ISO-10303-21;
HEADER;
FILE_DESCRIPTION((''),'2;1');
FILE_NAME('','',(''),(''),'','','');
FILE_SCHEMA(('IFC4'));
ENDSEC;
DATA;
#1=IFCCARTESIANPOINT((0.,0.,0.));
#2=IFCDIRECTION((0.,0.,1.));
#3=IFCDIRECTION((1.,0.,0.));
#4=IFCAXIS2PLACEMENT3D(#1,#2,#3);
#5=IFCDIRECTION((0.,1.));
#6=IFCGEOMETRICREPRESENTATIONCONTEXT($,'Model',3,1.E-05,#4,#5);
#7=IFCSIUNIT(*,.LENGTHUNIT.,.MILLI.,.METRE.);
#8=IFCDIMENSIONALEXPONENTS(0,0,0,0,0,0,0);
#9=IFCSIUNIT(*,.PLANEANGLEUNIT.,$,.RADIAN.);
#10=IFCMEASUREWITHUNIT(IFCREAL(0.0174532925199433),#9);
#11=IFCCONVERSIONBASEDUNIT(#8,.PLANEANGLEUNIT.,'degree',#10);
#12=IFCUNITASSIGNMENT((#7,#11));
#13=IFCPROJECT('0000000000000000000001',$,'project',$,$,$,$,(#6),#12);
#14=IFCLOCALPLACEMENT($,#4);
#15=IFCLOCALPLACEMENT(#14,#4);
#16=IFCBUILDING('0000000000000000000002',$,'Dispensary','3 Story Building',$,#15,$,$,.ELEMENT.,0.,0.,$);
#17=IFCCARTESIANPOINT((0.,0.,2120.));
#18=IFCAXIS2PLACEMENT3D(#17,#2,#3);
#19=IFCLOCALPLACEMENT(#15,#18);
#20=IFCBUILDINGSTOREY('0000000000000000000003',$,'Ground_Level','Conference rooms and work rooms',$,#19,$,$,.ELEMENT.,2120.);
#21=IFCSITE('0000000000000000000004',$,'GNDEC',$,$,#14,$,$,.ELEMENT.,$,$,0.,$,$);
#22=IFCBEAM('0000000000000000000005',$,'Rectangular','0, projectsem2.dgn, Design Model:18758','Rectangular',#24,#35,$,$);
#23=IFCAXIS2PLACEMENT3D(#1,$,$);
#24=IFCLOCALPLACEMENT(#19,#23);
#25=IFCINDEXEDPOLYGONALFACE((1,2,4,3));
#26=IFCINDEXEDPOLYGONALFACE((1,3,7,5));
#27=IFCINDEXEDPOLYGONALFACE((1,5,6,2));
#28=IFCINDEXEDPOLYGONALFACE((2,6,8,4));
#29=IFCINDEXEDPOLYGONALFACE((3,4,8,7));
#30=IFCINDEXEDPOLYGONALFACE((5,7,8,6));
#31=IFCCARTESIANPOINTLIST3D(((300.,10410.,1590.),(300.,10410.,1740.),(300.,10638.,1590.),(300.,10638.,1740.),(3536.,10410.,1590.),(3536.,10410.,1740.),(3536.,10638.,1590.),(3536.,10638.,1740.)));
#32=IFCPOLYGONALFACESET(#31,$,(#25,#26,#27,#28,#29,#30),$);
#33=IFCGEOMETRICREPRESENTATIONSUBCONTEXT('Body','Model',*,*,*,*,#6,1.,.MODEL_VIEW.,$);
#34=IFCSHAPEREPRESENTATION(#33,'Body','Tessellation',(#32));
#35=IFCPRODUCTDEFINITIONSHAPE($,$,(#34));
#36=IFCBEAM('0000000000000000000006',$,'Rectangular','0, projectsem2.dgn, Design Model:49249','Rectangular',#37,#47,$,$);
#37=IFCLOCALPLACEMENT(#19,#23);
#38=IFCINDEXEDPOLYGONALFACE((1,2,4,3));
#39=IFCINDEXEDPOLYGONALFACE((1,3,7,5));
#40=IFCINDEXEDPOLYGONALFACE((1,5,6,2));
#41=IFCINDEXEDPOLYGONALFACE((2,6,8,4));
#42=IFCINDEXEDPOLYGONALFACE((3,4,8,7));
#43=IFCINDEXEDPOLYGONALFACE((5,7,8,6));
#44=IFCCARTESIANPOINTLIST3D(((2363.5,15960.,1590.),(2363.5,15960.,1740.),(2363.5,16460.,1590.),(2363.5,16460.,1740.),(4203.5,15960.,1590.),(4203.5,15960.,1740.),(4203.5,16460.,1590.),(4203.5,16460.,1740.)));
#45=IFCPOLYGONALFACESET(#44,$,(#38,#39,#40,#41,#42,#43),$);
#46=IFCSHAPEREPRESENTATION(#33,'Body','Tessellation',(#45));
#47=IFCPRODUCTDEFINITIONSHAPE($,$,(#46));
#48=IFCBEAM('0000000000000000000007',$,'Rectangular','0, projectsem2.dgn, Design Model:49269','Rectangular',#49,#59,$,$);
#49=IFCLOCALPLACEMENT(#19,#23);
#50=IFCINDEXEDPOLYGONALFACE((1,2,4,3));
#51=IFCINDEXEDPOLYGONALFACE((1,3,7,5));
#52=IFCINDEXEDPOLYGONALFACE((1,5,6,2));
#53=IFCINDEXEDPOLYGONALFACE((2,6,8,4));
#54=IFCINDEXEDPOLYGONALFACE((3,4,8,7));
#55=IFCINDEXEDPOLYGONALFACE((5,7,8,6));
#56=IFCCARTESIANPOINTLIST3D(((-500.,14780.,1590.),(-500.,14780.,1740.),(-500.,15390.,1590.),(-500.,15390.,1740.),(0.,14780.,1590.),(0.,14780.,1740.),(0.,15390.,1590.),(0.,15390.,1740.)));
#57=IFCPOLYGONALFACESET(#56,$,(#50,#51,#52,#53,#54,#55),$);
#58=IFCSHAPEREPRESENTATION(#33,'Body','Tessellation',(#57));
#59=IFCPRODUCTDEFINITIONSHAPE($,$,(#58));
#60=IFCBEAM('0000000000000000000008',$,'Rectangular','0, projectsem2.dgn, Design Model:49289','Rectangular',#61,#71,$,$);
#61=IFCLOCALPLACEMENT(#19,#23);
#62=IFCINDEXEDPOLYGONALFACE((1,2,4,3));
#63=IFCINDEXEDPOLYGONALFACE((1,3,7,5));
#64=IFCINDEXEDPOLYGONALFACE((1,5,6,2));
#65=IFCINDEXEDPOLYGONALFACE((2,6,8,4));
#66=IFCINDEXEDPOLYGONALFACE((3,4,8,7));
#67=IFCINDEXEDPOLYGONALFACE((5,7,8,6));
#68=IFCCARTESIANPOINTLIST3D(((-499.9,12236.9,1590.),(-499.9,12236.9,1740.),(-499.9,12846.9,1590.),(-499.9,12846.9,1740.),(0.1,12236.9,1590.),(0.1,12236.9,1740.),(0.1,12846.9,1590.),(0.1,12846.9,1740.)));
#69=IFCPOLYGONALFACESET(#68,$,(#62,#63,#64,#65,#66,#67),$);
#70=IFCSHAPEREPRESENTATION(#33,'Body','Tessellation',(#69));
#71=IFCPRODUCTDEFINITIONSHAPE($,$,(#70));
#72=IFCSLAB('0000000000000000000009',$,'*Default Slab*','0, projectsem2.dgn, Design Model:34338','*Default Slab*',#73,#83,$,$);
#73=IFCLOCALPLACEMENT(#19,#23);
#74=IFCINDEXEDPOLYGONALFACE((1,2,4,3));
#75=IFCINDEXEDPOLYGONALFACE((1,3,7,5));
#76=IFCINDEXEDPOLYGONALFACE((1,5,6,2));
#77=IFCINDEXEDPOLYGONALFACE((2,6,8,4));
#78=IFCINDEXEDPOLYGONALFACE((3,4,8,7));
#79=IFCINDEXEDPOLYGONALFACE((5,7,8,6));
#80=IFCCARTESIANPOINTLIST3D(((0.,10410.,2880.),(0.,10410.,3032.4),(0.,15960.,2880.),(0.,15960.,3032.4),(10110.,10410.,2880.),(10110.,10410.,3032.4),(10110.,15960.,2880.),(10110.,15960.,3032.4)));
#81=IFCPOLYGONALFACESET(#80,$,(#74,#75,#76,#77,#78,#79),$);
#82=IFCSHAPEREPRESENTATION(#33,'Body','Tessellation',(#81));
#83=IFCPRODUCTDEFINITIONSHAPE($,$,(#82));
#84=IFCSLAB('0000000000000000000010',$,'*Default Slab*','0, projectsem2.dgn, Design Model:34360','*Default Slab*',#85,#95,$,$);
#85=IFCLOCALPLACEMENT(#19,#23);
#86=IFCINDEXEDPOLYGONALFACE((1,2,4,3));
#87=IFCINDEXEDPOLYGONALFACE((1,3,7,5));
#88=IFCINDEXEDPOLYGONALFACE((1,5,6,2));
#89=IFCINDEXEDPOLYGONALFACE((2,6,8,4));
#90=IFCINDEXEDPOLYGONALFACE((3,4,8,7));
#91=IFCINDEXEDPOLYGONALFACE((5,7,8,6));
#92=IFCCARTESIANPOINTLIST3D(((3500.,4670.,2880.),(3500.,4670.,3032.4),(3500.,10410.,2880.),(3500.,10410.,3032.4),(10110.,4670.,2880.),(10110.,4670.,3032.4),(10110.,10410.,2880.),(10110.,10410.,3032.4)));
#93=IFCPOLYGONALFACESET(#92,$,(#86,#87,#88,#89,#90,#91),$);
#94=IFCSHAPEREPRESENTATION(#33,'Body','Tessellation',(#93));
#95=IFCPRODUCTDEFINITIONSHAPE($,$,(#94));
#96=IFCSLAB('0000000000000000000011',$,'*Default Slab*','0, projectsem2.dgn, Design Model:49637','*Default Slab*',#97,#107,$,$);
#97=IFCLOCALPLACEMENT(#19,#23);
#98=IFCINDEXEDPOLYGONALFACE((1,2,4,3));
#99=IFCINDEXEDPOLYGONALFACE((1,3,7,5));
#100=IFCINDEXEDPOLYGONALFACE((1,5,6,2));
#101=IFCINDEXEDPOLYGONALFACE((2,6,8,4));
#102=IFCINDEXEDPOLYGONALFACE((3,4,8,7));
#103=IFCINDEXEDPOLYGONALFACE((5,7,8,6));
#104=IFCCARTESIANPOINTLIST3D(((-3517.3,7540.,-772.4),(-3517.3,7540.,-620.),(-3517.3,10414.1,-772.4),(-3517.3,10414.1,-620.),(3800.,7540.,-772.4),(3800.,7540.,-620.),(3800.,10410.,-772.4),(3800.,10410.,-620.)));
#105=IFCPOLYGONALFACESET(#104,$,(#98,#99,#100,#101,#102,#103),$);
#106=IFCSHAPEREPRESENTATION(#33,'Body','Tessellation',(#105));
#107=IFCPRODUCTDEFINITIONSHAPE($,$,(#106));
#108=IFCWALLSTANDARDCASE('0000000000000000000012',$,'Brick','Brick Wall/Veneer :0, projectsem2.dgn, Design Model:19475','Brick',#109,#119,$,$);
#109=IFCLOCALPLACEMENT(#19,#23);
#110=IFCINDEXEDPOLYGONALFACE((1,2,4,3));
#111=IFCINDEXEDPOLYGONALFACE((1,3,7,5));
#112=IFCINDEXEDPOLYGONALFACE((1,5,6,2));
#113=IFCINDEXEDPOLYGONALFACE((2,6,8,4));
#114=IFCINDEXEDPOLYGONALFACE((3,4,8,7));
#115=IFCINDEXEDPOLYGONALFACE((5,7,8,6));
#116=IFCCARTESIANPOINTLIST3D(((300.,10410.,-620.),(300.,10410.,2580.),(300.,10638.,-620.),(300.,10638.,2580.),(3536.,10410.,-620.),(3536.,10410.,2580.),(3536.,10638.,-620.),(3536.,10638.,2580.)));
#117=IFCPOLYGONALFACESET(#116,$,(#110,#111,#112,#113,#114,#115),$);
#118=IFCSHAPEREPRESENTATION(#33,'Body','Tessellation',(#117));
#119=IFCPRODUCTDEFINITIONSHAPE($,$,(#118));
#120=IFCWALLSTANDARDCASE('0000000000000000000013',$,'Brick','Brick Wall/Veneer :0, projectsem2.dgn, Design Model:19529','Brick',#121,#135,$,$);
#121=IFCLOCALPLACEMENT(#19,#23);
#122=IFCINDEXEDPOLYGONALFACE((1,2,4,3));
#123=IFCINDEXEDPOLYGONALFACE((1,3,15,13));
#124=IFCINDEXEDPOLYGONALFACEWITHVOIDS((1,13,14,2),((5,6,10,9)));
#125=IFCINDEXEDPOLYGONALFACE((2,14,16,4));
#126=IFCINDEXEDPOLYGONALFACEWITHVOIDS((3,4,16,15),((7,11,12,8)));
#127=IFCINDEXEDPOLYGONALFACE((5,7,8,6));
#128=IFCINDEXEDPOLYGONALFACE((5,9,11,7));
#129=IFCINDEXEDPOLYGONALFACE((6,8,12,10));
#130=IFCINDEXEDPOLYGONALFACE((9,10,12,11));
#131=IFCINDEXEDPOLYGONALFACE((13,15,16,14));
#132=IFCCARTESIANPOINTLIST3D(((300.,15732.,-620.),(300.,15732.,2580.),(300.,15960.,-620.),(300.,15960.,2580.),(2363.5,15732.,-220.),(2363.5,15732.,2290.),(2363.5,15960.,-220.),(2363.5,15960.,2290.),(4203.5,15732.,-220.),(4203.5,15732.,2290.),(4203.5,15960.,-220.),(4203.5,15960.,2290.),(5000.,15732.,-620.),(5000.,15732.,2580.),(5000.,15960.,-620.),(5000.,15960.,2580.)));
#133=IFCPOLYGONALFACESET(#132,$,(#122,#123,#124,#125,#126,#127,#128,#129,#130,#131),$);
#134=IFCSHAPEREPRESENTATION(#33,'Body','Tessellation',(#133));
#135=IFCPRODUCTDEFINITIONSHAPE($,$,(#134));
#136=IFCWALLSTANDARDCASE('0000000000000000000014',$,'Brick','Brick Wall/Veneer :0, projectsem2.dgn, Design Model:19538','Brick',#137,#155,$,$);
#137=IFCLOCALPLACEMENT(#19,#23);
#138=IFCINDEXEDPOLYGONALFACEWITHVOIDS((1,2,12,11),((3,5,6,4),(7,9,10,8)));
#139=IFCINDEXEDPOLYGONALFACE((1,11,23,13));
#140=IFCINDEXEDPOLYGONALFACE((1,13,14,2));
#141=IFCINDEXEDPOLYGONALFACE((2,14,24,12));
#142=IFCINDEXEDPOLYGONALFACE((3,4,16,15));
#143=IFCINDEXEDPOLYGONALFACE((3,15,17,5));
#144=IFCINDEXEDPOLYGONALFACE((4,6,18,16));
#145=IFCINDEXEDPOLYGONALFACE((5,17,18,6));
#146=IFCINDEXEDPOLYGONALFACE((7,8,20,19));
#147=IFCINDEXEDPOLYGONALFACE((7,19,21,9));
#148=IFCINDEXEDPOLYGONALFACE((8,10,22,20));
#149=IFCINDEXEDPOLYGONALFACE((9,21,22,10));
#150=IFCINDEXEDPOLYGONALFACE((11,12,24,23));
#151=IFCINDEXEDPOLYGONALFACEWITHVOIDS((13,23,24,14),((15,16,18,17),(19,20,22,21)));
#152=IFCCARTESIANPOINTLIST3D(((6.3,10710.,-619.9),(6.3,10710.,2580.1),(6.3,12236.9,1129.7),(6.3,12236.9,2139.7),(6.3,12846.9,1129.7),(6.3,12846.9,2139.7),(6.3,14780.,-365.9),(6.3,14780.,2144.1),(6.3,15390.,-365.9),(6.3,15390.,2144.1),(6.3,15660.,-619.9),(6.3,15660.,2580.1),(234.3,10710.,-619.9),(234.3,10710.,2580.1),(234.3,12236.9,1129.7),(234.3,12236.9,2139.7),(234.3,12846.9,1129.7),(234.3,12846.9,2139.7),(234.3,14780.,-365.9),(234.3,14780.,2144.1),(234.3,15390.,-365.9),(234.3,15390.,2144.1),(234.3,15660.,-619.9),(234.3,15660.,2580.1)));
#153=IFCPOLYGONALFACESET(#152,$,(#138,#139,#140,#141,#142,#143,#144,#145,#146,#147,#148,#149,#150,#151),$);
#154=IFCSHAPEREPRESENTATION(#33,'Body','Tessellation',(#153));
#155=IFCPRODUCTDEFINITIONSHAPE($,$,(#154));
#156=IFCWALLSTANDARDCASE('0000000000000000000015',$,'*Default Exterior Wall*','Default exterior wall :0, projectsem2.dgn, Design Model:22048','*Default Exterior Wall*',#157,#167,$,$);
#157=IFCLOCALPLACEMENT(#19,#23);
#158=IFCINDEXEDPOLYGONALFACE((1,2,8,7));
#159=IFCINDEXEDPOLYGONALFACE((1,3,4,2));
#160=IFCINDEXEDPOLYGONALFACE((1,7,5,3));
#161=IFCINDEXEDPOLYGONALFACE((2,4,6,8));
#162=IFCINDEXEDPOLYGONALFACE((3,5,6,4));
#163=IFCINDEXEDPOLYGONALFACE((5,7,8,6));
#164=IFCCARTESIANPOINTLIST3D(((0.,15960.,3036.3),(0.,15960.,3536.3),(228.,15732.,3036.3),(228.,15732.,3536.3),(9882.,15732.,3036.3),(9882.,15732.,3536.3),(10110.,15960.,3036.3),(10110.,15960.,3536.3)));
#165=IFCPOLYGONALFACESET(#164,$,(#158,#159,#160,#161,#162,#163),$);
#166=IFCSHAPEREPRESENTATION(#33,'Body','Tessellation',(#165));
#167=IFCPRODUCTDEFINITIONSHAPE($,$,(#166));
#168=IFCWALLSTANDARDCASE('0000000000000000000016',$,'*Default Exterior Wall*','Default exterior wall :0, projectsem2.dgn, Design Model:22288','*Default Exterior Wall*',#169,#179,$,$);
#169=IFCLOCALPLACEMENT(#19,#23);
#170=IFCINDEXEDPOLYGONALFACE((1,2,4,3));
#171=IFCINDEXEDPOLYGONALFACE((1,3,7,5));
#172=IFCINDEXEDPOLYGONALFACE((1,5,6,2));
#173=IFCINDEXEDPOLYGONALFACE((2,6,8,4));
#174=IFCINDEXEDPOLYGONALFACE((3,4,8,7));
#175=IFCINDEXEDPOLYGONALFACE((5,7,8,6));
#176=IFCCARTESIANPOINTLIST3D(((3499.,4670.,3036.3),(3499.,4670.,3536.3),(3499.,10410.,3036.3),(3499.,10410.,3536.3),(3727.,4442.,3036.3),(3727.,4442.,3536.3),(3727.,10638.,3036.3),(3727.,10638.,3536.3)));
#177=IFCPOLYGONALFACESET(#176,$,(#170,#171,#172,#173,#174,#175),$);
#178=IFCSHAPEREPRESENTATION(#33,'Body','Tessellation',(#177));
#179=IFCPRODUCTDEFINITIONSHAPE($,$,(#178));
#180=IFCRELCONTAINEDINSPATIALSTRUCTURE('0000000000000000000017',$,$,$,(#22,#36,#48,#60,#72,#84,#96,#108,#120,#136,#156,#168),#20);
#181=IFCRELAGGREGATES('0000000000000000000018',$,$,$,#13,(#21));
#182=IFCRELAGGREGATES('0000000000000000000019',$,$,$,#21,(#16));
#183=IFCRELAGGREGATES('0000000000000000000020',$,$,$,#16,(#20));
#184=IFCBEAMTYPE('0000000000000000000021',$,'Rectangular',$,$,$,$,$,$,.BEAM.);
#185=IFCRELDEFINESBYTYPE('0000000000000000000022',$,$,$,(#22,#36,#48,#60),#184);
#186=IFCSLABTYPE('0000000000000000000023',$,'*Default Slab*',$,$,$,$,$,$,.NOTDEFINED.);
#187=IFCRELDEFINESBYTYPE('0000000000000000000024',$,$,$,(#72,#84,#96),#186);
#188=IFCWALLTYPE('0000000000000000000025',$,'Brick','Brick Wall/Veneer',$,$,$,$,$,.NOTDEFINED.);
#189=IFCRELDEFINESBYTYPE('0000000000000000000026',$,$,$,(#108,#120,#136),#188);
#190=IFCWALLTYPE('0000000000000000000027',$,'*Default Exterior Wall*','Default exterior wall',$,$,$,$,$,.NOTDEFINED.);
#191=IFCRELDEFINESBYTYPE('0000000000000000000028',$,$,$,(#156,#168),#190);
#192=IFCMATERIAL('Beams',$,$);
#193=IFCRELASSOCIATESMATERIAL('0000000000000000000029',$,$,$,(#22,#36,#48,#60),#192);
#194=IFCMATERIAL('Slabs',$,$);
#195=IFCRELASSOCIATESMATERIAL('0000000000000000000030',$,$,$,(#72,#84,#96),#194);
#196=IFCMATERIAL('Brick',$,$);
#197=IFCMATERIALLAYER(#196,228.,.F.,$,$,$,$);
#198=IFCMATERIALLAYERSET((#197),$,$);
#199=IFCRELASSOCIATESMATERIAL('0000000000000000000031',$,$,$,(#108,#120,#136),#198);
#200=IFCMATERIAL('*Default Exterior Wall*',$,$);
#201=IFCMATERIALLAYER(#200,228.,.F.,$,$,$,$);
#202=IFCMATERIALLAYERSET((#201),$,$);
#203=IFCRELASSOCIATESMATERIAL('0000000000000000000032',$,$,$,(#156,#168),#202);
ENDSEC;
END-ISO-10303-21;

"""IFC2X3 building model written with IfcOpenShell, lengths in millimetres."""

from ifc_helpers import new_model, entity, si_unit, converted_unit, direction, frame, frame_2d, origin_with_axes, place, context, subcontext, project, spatial, polyline, rectangle, outline, extrude, material, layer, layer_set, layer_usage, type_object, element, save


model = new_model("IFC2X3")

# Units and contexts
model_context = context("Model", 3, precision=1e-05, world=origin_with_axes(), true_north=direction((0.0, 1.0)))
body_context = subcontext(model_context, "Body", "Model", "MODEL_VIEW", scale=1.0)
ifc_project = project(units=[si_unit("LENGTHUNIT", "METRE", prefix="MILLI"), converted_unit("PLANEANGLEUNIT", "degree", entity("IfcReal", 0.0174532925199433), si_unit("PLANEANGLEUNIT", "RADIAN"), dimensions=[0, 0, 0, 0, 0, 0, 0])], contexts=[model_context])

# Site, building, storey
site_placement = place(None, origin_with_axes())
site = spatial("IfcSite", under=ifc_project, at=site_placement, Name="GNDEC", CompositionType="ELEMENT", RefElevation=0.0)
building_placement = place(site_placement, origin_with_axes())
building = spatial("IfcBuilding", under=site, at=building_placement, Name="Dispensary", Description="3 Story Building", CompositionType="ELEMENT", ElevationOfRefHeight=0.0, ElevationOfTerrain=0.0)
storey_placement = place(building_placement, frame((0.0, 0.0, 2120.0), z_axis=(0.0, 0.0, 1.0), x_axis=(1.0, 0.0, 0.0)))
storey = spatial("IfcBuildingStorey", under=building, at=storey_placement, Name="Ground_Level", Description="Conference rooms and work rooms", CompositionType="ELEMENT", Elevation=2120.0)

# Beams
ifc_material_1 = material(Name="Beams")
beam_type = type_object("IfcBeamType", Name="Rectangular", PredefinedType="BEAM")
beam_1_placement = place(storey_placement, frame((300.0, 10410.0, 1590.0), z_axis=(1.0, 0.0, 0.0), x_axis=(0.0, 1.0, 0.0)))
element("IfcBeam", 1, at=beam_1_placement, inside=storey, type_object=beam_type, material=ifc_material_1, Name="Rectangular", Description="0, projectsem2.dgn, Design Model:18758", ObjectType="Rectangular", context=body_context, shape_type="SweptSolid", body=[
    extrude(rectangle(XDim=150.0, YDim=228.0, at=frame_2d((114.0, 75.0), x_axis=(0.0, 1.0))), origin_with_axes(), (0.0, 0.0, 1.0), 3236.0),
])
beam_2_placement = place(storey_placement, frame((4203.5, 16460.0, 1590.0), z_axis=(-1.0, 0.0, 0.0), x_axis=(0.0, -1.0, 0.0)))
element("IfcBeam", 2, at=beam_2_placement, inside=storey, type_object=beam_type, material=ifc_material_1, Name="Rectangular", Description="0, projectsem2.dgn, Design Model:49249", ObjectType="Rectangular", context=body_context, shape_type="SweptSolid", body=[
    extrude(rectangle(XDim=150.0, YDim=500.0, at=frame_2d((250.0, 75.0), x_axis=(0.0, 1.0))), origin_with_axes(), (0.0, 0.0, 1.0), 1840.0),
])
for number, where, z_axis, x_axis, name, description in (
    (3, (-500.0, 15390.0, 1590.0), (0.000031, -1.0, 0.0), (1.0, 0.000031, 0.0), "Rectangular", "0, projectsem2.dgn, Design Model:49269"),
    (4, (-499.9, 12846.9, 1590.0), (0.000031, -1.0, 0.0), (1.0, 0.000031, 0.0), "Rectangular", "0, projectsem2.dgn, Design Model:49289"),
):
    element("IfcBeam", number, at=place(storey_placement, frame(where, z_axis=z_axis, x_axis=x_axis)), inside=storey, type_object=beam_type, material=ifc_material_1, Name=name, Description=description, ObjectType="Rectangular", context=body_context, shape_type="SweptSolid", body=[
        extrude(rectangle(XDim=150.0, YDim=500.0, at=frame_2d((250.0, 75.0), x_axis=(0.0, 1.0))), origin_with_axes(), (0.0, 0.0, 1.0), 610.0),
    ])

# Slabs
ifc_material_2 = material(Name="Slabs")
slab_type = type_object("IfcSlabType", Name="*Default Slab*", PredefinedType="NOTDEFINED")
slab_1_placement = place(storey_placement, frame((0.0, 10410.0, 2880.0), z_axis=(0.0, 0.0, 1.0), x_axis=(1.0, 0.0, 0.0)))
element("IfcSlab", 5, at=slab_1_placement, inside=storey, type_object=slab_type, material=ifc_material_2, Name="*Default Slab*", Description="0, projectsem2.dgn, Design Model:34338", ObjectType="*Default Slab*", context=body_context, shape_type="SweptSolid", body=[
    extrude(rectangle(XDim=10110.0, YDim=5550.0, at=frame_2d((5055.0, 2775.0), x_axis=(1.0, 0.0))), origin_with_axes(), (0.0, 0.0, 1.0), 152.4),
])
slab_2_placement = place(storey_placement, frame((3500.0, 10410.0, 2880.0), z_axis=(0.0, 0.0, 1.0), x_axis=(0.0, -1.0, 0.0)))
element("IfcSlab", 6, at=slab_2_placement, inside=storey, type_object=slab_type, material=ifc_material_2, Name="*Default Slab*", Description="0, projectsem2.dgn, Design Model:34360", ObjectType="*Default Slab*", context=body_context, shape_type="SweptSolid", body=[
    extrude(rectangle(XDim=5740.0, YDim=6610.0, at=frame_2d((2870.0, 3305.0), x_axis=(1.0, 0.0))), origin_with_axes(), (0.0, 0.0, 1.0), 152.4),
])
slab_3_placement = place(storey_placement, frame((3800.0, 10410.0, -620.0), z_axis=(0.0, 0.0, -1.0), x_axis=(0.0, -1.0, 0.0)))
element("IfcSlab", 7, at=slab_3_placement, inside=storey, type_object=slab_type, material=ifc_material_2, Name="*Default Slab*", Description="0, projectsem2.dgn, Design Model:49637", ObjectType="*Default Slab*", context=body_context, shape_type="SweptSolid", body=[
    extrude(outline(polyline([(0.0, 0.0), (2870.0, 0.0), (2870.0, 7317.3), (-4.1, 7317.3), (0.0, 0.0)])), origin_with_axes(), (0.0, 0.0, 1.0), 152.4),
])

# Wall
ifc_material_3 = material(Name="Brick")
ifc_layer_1 = layer(ifc_material_3, 228.0, ventilated=False)
ifc_layer_set_1 = layer_set([ifc_layer_1])
ifc_layer_usage_1 = layer_usage(ifc_layer_set_1, "AXIS2", "POSITIVE", 0.0)
wall_type_1 = type_object("IfcWallType", Name="Brick", Description="Brick Wall/Veneer", PredefinedType="NOTDEFINED")
wall_1_placement = place(storey_placement, frame((300.0, 10638.0, -620.0), z_axis=(0.0, 0.0, 1.0), x_axis=(1.0, 0.0, 0.0)))
element("IfcWallStandardCase", 8, at=wall_1_placement, inside=storey, type_object=wall_type_1, material=ifc_layer_usage_1, Name="Brick", Description="Brick Wall/Veneer :0, projectsem2.dgn, Design Model:19475", ObjectType="Brick", context=body_context, shape_type="SweptSolid", body=[
    extrude(rectangle(XDim=228.0, YDim=3236.0, at=frame_2d((1618.0, -114.0), x_axis=(0.0, -1.0))), origin_with_axes(), (0.0, 0.0, 1.0), 3200.0),
])

# Wall, opening
wall_2_placement = place(storey_placement, frame((300.0, 15960.0, -620.0), z_axis=(0.0, 0.0, 1.0), x_axis=(1.0, 0.0, 0.0)))
wall_2 = element("IfcWallStandardCase", 9, at=wall_2_placement, inside=storey, type_object=wall_type_1, material=ifc_layer_usage_1, Name="Brick", Description="Brick Wall/Veneer :0, projectsem2.dgn, Design Model:19529", ObjectType="Brick", context=body_context, shape_type="SweptSolid", body=[
    extrude(rectangle(XDim=4700.0, YDim=228.0, at=frame_2d((2350.0, -114.0), x_axis=(-1.0, 0.0))), origin_with_axes(), (0.0, 0.0, 1.0), 3200.0),
])
opening_1_placement = place(wall_2_placement, frame((2063.5, -228.0, 400.0), z_axis=(0.0, 0.0, 1.0), x_axis=(1.0, 0.0, 0.0)))
element("IfcOpeningElement", 10, at=opening_1_placement, cuts=wall_2, ObjectType="Opening", context=body_context, shape_type="SweptSolid", body=[
    extrude(rectangle(XDim=2510.0, YDim=1840.0, at=frame_2d((-920.0, 1255.0), x_axis=(0.0, -1.0))), frame((0.0, 0.0, 0.0), z_axis=(0.0, 1.0, 0.0), x_axis=(-1.0, 0.0, 0.0)), (0.0, 0.0, 1.0), 228.0),
])

# Wall, openings
wall_3_placement = place(storey_placement, frame((234.3, 15660.0, -619.9), z_axis=(0.0, 0.0, 1.0), x_axis=(0.0, -1.0, 0.0)))
wall_3 = element("IfcWallStandardCase", 11, at=wall_3_placement, inside=storey, type_object=wall_type_1, material=ifc_layer_usage_1, Name="Brick", Description="Brick Wall/Veneer :0, projectsem2.dgn, Design Model:19538", ObjectType="Brick", context=body_context, shape_type="SweptSolid", body=[
    extrude(rectangle(XDim=4950.0, YDim=228.0, at=frame_2d((2475.0, -114.0), x_axis=(-1.0, 0.0))), origin_with_axes(), (0.0, 0.0, 1.0), 3200.0),
])
opening_2_placement = place(wall_3_placement, frame((270.0, -228.0, 254.0), z_axis=(0.0, 0.0, 1.0), x_axis=(1.0, 0.0, 0.0)))
element("IfcOpeningElement", 12, at=opening_2_placement, cuts=wall_3, ObjectType="Opening", context=body_context, shape_type="SweptSolid", body=[
    extrude(rectangle(XDim=2510.0, YDim=610.0, at=frame_2d((-305.0, 1255.0), x_axis=(0.0, -1.0))), frame((0.0, 0.0, 0.0), z_axis=(0.0, 1.0, 0.0), x_axis=(-1.0, 0.0, 0.0)), (0.0, 0.0, 1.0), 228.0),
])
opening_3_placement = place(wall_3_placement, frame((2813.1, -228.0, 1749.6), z_axis=(0.0, 0.0, 1.0), x_axis=(1.0, 0.0, 0.0)))
element("IfcOpeningElement", 13, at=opening_3_placement, cuts=wall_3, ObjectType="Opening", context=body_context, shape_type="SweptSolid", body=[
    extrude(rectangle(XDim=1010.0, YDim=610.0, at=frame_2d((-305.0, 505.0), x_axis=(0.0, -1.0))), frame((0.0, 0.0, 0.0), z_axis=(0.0, 1.0, 0.0), x_axis=(-1.0, 0.0, 0.0)), (0.0, 0.0, 1.0), 228.0),
])

# Walls
ifc_material_4 = material(Name="*Default Exterior Wall*")
ifc_layer_2 = layer(ifc_material_4, 228.0, ventilated=False)
ifc_layer_set_2 = layer_set([ifc_layer_2])
ifc_layer_usage_2 = layer_usage(ifc_layer_set_2, "AXIS2", "POSITIVE", 0.0)
wall_type_2 = type_object("IfcWallType", Name="*Default Exterior Wall*", Description="Default exterior wall", PredefinedType="NOTDEFINED")
wall_4_placement = place(storey_placement, frame((0.0, 15960.0, 3036.3), z_axis=(0.0, 0.0, 1.0), x_axis=(1.0, 0.0, 0.0)))
element("IfcWallStandardCase", 14, at=wall_4_placement, inside=storey, type_object=wall_type_2, material=ifc_layer_usage_2, Name="*Default Exterior Wall*", Description="Default exterior wall :0, projectsem2.dgn, Design Model:22048", ObjectType="*Default Exterior Wall*", context=body_context, shape_type="SweptSolid", body=[
    extrude(outline(polyline([(10110.0, 0.0), (0.0, 0.0), (228.0, -228.0), (9882.0, -228.0), (10110.0, 0.0)])), origin_with_axes(), (0.0, 0.0, 1.0), 500.0),
])
wall_5_placement = place(storey_placement, frame((3727.0, 10638.0, 3036.3), z_axis=(0.0, 0.0, 1.0), x_axis=(0.0, -1.0, 0.0)))
element("IfcWallStandardCase", 15, at=wall_5_placement, inside=storey, type_object=wall_type_2, material=ifc_layer_usage_2, Name="*Default Exterior Wall*", Description="Default exterior wall :0, projectsem2.dgn, Design Model:22288", ObjectType="*Default Exterior Wall*", context=body_context, shape_type="SweptSolid", body=[
    extrude(outline(polyline([(6196.0, 0.0), (0.0, 0.0), (228.0, -228.0), (5968.0, -228.0), (6196.0, 0.0)])), origin_with_axes(), (0.0, 0.0, 1.0), 500.0),
])

save(model, "model.ifc")
